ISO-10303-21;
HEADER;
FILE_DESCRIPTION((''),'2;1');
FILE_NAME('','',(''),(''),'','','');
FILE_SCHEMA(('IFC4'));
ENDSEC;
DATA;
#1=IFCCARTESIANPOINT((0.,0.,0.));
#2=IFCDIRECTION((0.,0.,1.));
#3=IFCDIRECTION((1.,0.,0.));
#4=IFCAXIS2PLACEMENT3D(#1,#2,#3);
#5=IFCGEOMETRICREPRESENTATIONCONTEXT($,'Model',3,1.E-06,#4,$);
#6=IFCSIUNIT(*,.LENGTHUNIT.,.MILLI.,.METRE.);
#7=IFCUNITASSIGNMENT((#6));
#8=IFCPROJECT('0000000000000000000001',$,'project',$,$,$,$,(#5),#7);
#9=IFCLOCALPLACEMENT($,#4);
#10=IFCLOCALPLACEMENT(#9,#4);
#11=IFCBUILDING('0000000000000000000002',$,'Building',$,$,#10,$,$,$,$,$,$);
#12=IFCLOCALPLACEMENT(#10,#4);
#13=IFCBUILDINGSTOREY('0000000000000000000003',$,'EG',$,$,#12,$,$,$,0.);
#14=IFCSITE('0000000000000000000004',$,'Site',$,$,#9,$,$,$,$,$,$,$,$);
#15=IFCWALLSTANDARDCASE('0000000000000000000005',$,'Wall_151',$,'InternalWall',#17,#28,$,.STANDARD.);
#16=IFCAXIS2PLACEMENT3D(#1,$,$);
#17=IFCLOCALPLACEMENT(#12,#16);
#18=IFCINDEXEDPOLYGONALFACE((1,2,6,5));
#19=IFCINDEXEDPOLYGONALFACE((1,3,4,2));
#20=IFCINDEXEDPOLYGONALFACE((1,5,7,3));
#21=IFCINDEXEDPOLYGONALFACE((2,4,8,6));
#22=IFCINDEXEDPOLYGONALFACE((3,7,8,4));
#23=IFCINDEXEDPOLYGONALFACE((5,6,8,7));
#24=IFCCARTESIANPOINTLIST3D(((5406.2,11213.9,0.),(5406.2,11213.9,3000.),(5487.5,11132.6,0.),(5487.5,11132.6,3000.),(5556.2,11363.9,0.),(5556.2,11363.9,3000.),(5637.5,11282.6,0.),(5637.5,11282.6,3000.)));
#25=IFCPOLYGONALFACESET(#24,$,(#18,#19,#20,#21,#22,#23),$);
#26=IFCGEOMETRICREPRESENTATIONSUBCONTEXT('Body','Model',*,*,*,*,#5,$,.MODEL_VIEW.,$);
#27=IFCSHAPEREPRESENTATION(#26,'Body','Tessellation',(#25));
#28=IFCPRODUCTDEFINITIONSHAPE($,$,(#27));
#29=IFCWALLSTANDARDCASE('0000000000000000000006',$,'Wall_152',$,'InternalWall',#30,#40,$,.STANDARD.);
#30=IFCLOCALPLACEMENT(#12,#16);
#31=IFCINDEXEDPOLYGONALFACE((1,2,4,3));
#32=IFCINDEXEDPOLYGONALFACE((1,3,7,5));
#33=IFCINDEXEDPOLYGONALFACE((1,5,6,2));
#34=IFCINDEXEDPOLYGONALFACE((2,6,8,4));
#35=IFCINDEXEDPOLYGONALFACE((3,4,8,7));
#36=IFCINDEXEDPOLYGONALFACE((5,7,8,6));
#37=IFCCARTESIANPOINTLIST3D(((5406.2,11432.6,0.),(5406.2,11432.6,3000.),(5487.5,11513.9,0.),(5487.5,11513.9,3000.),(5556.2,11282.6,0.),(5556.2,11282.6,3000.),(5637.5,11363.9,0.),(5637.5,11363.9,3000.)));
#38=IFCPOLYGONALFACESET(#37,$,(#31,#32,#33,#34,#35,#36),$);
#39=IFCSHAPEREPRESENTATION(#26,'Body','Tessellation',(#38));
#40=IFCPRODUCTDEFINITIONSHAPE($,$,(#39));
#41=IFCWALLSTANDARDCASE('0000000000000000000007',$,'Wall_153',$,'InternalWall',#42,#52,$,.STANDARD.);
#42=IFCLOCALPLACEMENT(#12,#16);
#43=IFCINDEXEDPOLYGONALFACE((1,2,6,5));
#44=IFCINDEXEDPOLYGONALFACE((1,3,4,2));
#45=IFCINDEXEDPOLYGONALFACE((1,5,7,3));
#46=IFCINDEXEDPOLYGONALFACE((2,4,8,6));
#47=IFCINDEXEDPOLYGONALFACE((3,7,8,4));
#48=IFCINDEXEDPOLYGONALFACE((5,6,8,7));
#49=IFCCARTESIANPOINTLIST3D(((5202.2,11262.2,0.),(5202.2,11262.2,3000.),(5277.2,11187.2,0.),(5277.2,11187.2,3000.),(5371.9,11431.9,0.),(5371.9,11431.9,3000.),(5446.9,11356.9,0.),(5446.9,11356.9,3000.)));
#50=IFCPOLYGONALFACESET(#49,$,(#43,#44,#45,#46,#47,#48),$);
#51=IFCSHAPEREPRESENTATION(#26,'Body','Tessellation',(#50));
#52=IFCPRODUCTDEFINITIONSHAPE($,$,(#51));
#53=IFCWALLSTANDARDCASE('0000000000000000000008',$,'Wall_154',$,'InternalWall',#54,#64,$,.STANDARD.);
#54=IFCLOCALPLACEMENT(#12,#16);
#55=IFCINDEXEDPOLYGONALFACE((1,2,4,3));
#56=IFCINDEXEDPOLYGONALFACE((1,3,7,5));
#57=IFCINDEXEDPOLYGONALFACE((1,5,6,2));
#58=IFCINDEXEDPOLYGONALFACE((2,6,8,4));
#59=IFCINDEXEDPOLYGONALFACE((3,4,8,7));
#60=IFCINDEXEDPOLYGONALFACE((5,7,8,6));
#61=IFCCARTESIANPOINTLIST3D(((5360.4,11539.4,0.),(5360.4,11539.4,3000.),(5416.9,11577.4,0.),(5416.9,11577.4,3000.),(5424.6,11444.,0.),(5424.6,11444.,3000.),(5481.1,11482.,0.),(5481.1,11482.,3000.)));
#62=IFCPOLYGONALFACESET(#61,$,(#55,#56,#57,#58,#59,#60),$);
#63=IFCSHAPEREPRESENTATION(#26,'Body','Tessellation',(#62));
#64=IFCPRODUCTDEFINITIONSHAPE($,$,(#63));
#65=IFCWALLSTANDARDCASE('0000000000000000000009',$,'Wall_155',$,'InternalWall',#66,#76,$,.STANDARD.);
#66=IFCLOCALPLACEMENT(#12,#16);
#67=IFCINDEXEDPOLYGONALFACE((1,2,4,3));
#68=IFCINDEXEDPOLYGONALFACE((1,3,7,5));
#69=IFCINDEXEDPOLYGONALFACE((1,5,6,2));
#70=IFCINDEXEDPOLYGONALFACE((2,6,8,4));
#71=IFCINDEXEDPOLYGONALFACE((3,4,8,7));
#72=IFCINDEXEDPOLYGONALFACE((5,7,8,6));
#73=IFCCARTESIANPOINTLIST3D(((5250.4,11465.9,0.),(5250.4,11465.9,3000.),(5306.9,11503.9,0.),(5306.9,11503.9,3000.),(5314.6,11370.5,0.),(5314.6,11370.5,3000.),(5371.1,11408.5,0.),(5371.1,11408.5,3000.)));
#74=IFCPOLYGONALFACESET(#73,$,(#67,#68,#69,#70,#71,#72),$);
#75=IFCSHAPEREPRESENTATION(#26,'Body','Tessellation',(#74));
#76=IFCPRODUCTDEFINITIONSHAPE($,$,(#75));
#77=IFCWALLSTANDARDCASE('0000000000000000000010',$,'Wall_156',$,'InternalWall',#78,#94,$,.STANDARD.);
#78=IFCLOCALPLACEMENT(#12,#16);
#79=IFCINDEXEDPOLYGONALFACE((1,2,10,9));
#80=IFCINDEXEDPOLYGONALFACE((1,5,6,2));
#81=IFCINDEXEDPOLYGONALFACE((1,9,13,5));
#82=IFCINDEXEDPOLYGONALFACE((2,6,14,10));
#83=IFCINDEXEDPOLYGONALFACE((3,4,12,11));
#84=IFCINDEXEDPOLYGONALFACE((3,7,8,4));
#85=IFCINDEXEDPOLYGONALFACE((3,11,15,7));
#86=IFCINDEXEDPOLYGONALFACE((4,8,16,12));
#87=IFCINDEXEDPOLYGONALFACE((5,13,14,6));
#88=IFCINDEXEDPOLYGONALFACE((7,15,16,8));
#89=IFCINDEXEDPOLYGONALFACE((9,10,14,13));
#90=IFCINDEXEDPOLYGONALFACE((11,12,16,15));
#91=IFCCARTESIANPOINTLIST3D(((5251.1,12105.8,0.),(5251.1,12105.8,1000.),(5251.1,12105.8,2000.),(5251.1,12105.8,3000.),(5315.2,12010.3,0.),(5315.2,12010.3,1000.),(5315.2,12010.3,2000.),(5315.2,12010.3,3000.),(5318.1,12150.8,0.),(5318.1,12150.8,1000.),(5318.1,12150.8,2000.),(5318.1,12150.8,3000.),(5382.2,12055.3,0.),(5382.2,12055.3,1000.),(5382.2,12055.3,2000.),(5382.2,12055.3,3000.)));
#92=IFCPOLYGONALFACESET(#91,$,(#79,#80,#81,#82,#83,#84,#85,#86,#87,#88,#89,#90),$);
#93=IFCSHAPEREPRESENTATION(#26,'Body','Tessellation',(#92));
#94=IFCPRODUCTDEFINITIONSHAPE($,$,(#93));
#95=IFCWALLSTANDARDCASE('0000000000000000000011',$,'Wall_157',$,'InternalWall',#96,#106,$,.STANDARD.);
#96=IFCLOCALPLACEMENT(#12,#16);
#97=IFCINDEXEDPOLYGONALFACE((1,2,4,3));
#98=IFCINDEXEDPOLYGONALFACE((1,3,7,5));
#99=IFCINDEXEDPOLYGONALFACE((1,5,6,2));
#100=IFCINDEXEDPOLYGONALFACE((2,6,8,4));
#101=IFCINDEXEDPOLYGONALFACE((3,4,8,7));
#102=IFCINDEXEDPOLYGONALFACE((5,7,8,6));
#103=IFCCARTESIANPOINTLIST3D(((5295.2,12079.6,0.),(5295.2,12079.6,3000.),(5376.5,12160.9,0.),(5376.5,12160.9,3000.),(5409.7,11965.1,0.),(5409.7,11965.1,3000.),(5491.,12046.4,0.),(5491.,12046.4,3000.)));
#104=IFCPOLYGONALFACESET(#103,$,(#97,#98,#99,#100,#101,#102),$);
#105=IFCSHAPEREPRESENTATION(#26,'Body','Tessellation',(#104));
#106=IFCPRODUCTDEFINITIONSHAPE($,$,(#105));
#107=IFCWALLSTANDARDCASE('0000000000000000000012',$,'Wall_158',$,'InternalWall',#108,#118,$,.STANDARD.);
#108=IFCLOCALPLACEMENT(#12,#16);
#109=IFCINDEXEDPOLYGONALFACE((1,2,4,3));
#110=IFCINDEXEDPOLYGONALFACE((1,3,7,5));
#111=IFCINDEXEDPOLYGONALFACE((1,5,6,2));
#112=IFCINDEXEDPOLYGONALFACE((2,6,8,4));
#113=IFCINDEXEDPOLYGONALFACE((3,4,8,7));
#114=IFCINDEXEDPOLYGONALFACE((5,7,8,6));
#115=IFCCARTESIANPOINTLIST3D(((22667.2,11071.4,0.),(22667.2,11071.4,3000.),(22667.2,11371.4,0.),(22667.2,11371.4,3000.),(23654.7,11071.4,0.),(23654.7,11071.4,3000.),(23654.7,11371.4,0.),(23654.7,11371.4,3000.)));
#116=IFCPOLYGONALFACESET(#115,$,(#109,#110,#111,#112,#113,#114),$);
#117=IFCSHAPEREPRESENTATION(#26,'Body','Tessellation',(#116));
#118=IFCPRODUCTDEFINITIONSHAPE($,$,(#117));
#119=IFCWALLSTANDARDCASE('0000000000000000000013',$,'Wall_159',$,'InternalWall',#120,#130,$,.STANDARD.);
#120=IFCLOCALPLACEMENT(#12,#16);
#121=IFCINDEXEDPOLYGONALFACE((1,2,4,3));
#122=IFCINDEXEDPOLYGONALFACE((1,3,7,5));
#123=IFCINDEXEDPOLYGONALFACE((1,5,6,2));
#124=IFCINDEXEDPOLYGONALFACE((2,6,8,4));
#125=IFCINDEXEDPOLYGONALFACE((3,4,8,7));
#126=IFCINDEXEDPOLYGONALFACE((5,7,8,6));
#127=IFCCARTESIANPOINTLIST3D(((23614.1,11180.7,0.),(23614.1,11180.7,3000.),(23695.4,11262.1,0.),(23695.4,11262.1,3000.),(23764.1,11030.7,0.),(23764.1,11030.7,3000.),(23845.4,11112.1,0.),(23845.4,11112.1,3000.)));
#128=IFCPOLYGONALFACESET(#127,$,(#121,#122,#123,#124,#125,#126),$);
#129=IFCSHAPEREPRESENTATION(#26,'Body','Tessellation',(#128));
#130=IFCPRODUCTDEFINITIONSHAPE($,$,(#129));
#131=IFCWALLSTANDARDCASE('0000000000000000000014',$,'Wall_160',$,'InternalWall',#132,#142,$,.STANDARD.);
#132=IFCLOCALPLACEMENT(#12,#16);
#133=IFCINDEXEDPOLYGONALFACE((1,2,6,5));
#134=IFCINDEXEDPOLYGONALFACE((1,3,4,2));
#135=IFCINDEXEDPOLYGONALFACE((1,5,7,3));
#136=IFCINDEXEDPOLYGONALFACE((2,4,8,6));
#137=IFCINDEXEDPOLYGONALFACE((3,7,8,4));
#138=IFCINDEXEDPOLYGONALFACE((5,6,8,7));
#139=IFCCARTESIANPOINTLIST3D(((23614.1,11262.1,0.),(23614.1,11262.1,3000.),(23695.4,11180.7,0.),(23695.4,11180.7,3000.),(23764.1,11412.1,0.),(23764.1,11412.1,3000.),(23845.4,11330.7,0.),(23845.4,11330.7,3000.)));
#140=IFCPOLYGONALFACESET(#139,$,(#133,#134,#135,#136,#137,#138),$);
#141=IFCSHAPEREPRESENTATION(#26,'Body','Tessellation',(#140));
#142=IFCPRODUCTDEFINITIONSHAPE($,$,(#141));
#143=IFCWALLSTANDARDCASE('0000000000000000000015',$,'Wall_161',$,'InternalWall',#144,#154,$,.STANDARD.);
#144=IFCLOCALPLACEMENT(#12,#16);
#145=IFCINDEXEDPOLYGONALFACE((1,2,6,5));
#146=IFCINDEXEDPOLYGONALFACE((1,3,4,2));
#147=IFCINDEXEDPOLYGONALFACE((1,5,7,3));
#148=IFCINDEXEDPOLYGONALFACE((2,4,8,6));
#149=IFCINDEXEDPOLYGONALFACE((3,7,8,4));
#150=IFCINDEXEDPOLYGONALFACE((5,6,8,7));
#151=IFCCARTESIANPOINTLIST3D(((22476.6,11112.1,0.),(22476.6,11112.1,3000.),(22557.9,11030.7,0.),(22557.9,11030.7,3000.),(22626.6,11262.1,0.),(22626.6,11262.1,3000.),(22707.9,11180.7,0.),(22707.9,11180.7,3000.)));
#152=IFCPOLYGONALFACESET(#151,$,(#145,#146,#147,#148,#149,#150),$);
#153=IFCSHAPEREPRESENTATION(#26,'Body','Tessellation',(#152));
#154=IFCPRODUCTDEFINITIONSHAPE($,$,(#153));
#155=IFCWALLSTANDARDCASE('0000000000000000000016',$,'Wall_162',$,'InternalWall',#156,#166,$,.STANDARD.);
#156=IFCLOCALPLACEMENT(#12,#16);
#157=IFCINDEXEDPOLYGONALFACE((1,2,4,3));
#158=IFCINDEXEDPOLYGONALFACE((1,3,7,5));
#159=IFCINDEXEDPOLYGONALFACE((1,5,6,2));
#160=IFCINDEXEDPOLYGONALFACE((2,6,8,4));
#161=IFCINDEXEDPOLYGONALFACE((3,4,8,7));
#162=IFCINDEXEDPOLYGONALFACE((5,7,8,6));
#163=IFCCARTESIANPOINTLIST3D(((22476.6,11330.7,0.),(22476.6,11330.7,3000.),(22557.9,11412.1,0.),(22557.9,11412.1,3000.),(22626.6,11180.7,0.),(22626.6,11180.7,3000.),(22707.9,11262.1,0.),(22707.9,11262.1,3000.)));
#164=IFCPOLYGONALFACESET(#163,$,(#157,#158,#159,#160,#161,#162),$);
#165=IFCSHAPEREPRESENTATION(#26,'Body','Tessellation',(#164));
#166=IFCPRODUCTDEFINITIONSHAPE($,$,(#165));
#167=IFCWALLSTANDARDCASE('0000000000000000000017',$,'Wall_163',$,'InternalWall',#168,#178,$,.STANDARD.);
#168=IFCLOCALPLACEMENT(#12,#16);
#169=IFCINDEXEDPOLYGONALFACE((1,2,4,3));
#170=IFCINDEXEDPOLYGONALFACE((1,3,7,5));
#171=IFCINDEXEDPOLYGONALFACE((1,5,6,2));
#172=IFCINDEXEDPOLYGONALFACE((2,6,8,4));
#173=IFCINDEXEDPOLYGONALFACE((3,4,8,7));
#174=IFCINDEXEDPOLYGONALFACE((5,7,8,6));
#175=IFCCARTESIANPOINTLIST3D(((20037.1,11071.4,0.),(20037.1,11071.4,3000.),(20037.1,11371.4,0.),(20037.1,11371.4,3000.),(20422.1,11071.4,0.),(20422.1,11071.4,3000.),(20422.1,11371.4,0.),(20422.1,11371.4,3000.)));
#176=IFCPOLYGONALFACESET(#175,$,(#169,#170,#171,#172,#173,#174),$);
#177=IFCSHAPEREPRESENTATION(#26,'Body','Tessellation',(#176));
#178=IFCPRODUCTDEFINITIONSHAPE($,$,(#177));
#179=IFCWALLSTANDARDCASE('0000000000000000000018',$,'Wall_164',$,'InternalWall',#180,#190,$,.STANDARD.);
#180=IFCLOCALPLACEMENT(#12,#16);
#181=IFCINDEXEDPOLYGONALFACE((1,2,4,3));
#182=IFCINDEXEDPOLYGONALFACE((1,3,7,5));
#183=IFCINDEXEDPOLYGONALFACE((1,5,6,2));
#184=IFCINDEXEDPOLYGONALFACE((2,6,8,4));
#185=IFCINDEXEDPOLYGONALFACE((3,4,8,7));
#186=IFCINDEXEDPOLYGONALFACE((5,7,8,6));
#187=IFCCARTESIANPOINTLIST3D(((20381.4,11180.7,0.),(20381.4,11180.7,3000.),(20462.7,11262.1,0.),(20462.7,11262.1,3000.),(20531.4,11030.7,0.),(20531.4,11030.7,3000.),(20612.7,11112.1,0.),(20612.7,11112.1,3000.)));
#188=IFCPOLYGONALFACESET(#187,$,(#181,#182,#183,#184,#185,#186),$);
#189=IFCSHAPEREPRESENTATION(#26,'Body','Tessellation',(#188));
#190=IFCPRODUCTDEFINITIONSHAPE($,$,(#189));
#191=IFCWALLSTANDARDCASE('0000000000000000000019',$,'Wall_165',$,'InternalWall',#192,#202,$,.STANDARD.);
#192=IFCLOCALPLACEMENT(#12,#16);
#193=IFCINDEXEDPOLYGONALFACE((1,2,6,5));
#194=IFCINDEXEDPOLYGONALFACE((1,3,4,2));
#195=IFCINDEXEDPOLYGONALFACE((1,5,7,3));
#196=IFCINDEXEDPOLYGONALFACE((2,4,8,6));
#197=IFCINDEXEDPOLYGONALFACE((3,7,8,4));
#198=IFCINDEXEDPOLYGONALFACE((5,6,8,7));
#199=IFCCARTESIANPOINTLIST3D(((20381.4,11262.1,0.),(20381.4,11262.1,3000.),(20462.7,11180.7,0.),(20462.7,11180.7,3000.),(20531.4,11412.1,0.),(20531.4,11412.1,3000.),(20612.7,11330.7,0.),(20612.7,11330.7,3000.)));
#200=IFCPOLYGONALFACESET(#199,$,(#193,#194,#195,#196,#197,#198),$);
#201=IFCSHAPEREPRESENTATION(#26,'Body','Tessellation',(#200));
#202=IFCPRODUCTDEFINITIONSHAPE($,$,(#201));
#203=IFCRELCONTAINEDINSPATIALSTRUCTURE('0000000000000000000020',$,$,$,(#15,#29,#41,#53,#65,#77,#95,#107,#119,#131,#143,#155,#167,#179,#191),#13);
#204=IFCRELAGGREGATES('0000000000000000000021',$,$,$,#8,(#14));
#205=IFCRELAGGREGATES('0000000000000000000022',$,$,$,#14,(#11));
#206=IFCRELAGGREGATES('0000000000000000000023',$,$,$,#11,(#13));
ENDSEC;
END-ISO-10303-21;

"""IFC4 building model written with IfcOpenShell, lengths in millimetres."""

from ifc_helpers import new_model, si_unit, frame, origin_with_axes, place, context, subcontext, project, spatial, rectangle, extrude, element, save


model = new_model("IFC4")

# Units and contexts
model_context = context("Model", 3, precision=1e-06, world=origin_with_axes())
body_context = subcontext(model_context, "Body", "Model", "MODEL_VIEW")
ifc_project = project(units=[si_unit("LENGTHUNIT", "METRE", prefix="MILLI")], contexts=[model_context])

# Site, building, storey
site_placement = place(None, origin_with_axes())
site = spatial("IfcSite", under=ifc_project, at=site_placement, Name="Site")
building_placement = place(site_placement, origin_with_axes())
building = spatial("IfcBuilding", under=site, at=building_placement, Name="Building")
storey_placement = place(building_placement, origin_with_axes())
storey = spatial("IfcBuildingStorey", under=building, at=storey_placement, Name="EG", Elevation=0.0)

# Walls
wall_1_placement = place(storey_placement, origin_with_axes())
element("IfcWallStandardCase", 1, at=wall_1_placement, inside=storey, Name="Wall_151", ObjectType="InternalWall", PredefinedType="STANDARD", context=body_context, shape_type="SweptSolid", body=[
    extrude(rectangle(XDim=212.1, YDim=115.0), frame((5521.9, 11248.3, 0.0), z_axis=(0.0, 0.0, 1.0), x_axis=(-0.707107, -0.707107, 0.0)), (0.0, 0.0, 1.0), 3000.0),
])
wall_2_placement = place(storey_placement, origin_with_axes())
element("IfcWallStandardCase", 2, at=wall_2_placement, inside=storey, Name="Wall_152", ObjectType="InternalWall", PredefinedType="STANDARD", context=body_context, shape_type="SweptSolid", body=[
    extrude(rectangle(XDim=212.1, YDim=115.0), frame((5521.9, 11398.3, 0.0), z_axis=(0.0, 0.0, 1.0), x_axis=(-0.707107, 0.707107, 0.0)), (0.0, 0.0, 1.0), 3000.0),
])
wall_3_placement = place(storey_placement, origin_with_axes())
element("IfcWallStandardCase", 3, at=wall_3_placement, inside=storey, Name="Wall_153", ObjectType="InternalWall", PredefinedType="STANDARD", context=body_context, shape_type="SweptSolid", body=[
    extrude(rectangle(XDim=106.1, YDim=240.0), frame((5324.5, 11309.5, 0.0), z_axis=(0.0, 0.0, 1.0), x_axis=(0.707107, -0.707107, 0.0)), (0.0, 0.0, 1.0), 3000.0),
])
wall_4_placement = place(storey_placement, origin_with_axes())
element("IfcWallStandardCase", 4, at=wall_4_placement, inside=storey, Name="Wall_154", ObjectType="InternalWall", PredefinedType="STANDARD", context=body_context, shape_type="SweptSolid", body=[
    extrude(rectangle(XDim=68.1, YDim=115.0), frame((5420.7, 11510.7, 0.0), z_axis=(0.0, 0.0, 1.0), x_axis=(-0.829784, -0.558085, 0.0)), (0.0, 0.0, 1.0), 3000.0),
])
wall_5_placement = place(storey_placement, origin_with_axes())
element("IfcWallStandardCase", 5, at=wall_5_placement, inside=storey, Name="Wall_155", ObjectType="InternalWall", PredefinedType="STANDARD", context=body_context, shape_type="SweptSolid", body=[
    extrude(rectangle(XDim=68.1, YDim=115.0), frame((5310.7, 11437.2, 0.0), z_axis=(0.0, 0.0, 1.0), x_axis=(-0.829784, -0.558085, 0.0)), (0.0, 0.0, 1.0), 3000.0),
])

# Wall, opening
wall_6_placement = place(storey_placement, origin_with_axes())
wall_6 = element("IfcWallStandardCase", 6, at=wall_6_placement, inside=storey, Name="Wall_156", ObjectType="InternalWall", PredefinedType="STANDARD", context=body_context, shape_type="SweptSolid", body=[
    extrude(rectangle(XDim=80.7, YDim=115.0), frame((5316.6, 12080.6, 0.0), z_axis=(0.0, 0.0, 1.0), x_axis=(-0.830139, -0.557556, 0.0)), (0.0, 0.0, 1.0), 3000.0),
])
opening_1_placement = place(wall_6_placement, origin_with_axes())
element("IfcOpeningElement", 7, at=opening_1_placement, inside=storey, cuts=wall_6, context=body_context, shape_type="SweptSolid", body=[
    extrude(rectangle(XDim=600.0, YDim=115.0), frame((5314.5, 12079.1, 1000.0), z_axis=(0.0, 0.0, 1.0), x_axis=(-0.830139, -0.557556, 0.0)), (0.0, 0.0, 1.0), 1000.0),
])

# Walls
wall_7_placement = place(storey_placement, origin_with_axes())
element("IfcWallStandardCase", 8, at=wall_7_placement, inside=storey, Name="Wall_157", ObjectType="InternalWall", PredefinedType="STANDARD", context=body_context, shape_type="SweptSolid", body=[
    extrude(rectangle(XDim=161.9, YDim=115.0), frame((5393.1, 12063.0, 0.0), z_axis=(0.0, 0.0, 1.0), x_axis=(0.707107, -0.707107, 0.0)), (0.0, 0.0, 1.0), 3000.0),
])
wall_8_placement = place(storey_placement, origin_with_axes())
element("IfcWallStandardCase", 9, at=wall_8_placement, inside=storey, Name="Wall_158", ObjectType="InternalWall", PredefinedType="STANDARD", context=body_context, shape_type="SweptSolid", body=[
    extrude(rectangle(XDim=987.5, YDim=300.0), frame((23161.0, 11221.4, 0.0), z_axis=(0.0, 0.0, 1.0), x_axis=(-1.0, 0.0, 0.0)), (0.0, 0.0, 1.0), 3000.0),
])
wall_9_placement = place(storey_placement, origin_with_axes())
element("IfcWallStandardCase", 10, at=wall_9_placement, inside=storey, Name="Wall_159", ObjectType="InternalWall", PredefinedType="STANDARD", context=body_context, shape_type="SweptSolid", body=[
    extrude(rectangle(XDim=212.1, YDim=115.0), frame((23729.7, 11146.4, 0.0), z_axis=(0.0, 0.0, 1.0), x_axis=(0.707107, -0.707107, 0.0)), (0.0, 0.0, 1.0), 3000.0),
])
wall_10_placement = place(storey_placement, origin_with_axes())
element("IfcWallStandardCase", 11, at=wall_10_placement, inside=storey, Name="Wall_160", ObjectType="InternalWall", PredefinedType="STANDARD", context=body_context, shape_type="SweptSolid", body=[
    extrude(rectangle(XDim=212.1, YDim=115.0), frame((23729.7, 11296.4, 0.0), z_axis=(0.0, 0.0, 1.0), x_axis=(0.707107, 0.707107, 0.0)), (0.0, 0.0, 1.0), 3000.0),
])
wall_11_placement = place(storey_placement, origin_with_axes())
element("IfcWallStandardCase", 12, at=wall_11_placement, inside=storey, Name="Wall_161", ObjectType="InternalWall", PredefinedType="STANDARD", context=body_context, shape_type="SweptSolid", body=[
    extrude(rectangle(XDim=212.1, YDim=115.0), frame((22592.2, 11146.4, 0.0), z_axis=(0.0, 0.0, 1.0), x_axis=(-0.707107, -0.707107, 0.0)), (0.0, 0.0, 1.0), 3000.0),
])
wall_12_placement = place(storey_placement, origin_with_axes())
element("IfcWallStandardCase", 13, at=wall_12_placement, inside=storey, Name="Wall_162", ObjectType="InternalWall", PredefinedType="STANDARD", context=body_context, shape_type="SweptSolid", body=[
    extrude(rectangle(XDim=212.1, YDim=115.0), frame((22592.2, 11296.4, 0.0), z_axis=(0.0, 0.0, 1.0), x_axis=(-0.707107, 0.707107, 0.0)), (0.0, 0.0, 1.0), 3000.0),
])
wall_13_placement = place(storey_placement, origin_with_axes())
element("IfcWallStandardCase", 14, at=wall_13_placement, inside=storey, Name="Wall_163", ObjectType="InternalWall", PredefinedType="STANDARD", context=body_context, shape_type="SweptSolid", body=[
    extrude(rectangle(XDim=385.0, YDim=300.0), frame((20229.6, 11221.4, 0.0), z_axis=(0.0, 0.0, 1.0), x_axis=(-1.0, 0.0, 0.0)), (0.0, 0.0, 1.0), 3000.0),
])
wall_14_placement = place(storey_placement, origin_with_axes())
element("IfcWallStandardCase", 15, at=wall_14_placement, inside=storey, Name="Wall_164", ObjectType="InternalWall", PredefinedType="STANDARD", context=body_context, shape_type="SweptSolid", body=[
    extrude(rectangle(XDim=212.1, YDim=115.0), frame((20497.1, 11146.4, 0.0), z_axis=(0.0, 0.0, 1.0), x_axis=(0.707107, -0.707107, 0.0)), (0.0, 0.0, 1.0), 3000.0),
])
wall_15_placement = place(storey_placement, origin_with_axes())
element("IfcWallStandardCase", 16, at=wall_15_placement, inside=storey, Name="Wall_165", ObjectType="InternalWall", PredefinedType="STANDARD", context=body_context, shape_type="SweptSolid", body=[
    extrude(rectangle(XDim=212.1, YDim=115.0), frame((20497.1, 11296.4, 0.0), z_axis=(0.0, 0.0, 1.0), x_axis=(0.707107, 0.707107, 0.0)), (0.0, 0.0, 1.0), 3000.0),
])

save(model, "model.ifc")
